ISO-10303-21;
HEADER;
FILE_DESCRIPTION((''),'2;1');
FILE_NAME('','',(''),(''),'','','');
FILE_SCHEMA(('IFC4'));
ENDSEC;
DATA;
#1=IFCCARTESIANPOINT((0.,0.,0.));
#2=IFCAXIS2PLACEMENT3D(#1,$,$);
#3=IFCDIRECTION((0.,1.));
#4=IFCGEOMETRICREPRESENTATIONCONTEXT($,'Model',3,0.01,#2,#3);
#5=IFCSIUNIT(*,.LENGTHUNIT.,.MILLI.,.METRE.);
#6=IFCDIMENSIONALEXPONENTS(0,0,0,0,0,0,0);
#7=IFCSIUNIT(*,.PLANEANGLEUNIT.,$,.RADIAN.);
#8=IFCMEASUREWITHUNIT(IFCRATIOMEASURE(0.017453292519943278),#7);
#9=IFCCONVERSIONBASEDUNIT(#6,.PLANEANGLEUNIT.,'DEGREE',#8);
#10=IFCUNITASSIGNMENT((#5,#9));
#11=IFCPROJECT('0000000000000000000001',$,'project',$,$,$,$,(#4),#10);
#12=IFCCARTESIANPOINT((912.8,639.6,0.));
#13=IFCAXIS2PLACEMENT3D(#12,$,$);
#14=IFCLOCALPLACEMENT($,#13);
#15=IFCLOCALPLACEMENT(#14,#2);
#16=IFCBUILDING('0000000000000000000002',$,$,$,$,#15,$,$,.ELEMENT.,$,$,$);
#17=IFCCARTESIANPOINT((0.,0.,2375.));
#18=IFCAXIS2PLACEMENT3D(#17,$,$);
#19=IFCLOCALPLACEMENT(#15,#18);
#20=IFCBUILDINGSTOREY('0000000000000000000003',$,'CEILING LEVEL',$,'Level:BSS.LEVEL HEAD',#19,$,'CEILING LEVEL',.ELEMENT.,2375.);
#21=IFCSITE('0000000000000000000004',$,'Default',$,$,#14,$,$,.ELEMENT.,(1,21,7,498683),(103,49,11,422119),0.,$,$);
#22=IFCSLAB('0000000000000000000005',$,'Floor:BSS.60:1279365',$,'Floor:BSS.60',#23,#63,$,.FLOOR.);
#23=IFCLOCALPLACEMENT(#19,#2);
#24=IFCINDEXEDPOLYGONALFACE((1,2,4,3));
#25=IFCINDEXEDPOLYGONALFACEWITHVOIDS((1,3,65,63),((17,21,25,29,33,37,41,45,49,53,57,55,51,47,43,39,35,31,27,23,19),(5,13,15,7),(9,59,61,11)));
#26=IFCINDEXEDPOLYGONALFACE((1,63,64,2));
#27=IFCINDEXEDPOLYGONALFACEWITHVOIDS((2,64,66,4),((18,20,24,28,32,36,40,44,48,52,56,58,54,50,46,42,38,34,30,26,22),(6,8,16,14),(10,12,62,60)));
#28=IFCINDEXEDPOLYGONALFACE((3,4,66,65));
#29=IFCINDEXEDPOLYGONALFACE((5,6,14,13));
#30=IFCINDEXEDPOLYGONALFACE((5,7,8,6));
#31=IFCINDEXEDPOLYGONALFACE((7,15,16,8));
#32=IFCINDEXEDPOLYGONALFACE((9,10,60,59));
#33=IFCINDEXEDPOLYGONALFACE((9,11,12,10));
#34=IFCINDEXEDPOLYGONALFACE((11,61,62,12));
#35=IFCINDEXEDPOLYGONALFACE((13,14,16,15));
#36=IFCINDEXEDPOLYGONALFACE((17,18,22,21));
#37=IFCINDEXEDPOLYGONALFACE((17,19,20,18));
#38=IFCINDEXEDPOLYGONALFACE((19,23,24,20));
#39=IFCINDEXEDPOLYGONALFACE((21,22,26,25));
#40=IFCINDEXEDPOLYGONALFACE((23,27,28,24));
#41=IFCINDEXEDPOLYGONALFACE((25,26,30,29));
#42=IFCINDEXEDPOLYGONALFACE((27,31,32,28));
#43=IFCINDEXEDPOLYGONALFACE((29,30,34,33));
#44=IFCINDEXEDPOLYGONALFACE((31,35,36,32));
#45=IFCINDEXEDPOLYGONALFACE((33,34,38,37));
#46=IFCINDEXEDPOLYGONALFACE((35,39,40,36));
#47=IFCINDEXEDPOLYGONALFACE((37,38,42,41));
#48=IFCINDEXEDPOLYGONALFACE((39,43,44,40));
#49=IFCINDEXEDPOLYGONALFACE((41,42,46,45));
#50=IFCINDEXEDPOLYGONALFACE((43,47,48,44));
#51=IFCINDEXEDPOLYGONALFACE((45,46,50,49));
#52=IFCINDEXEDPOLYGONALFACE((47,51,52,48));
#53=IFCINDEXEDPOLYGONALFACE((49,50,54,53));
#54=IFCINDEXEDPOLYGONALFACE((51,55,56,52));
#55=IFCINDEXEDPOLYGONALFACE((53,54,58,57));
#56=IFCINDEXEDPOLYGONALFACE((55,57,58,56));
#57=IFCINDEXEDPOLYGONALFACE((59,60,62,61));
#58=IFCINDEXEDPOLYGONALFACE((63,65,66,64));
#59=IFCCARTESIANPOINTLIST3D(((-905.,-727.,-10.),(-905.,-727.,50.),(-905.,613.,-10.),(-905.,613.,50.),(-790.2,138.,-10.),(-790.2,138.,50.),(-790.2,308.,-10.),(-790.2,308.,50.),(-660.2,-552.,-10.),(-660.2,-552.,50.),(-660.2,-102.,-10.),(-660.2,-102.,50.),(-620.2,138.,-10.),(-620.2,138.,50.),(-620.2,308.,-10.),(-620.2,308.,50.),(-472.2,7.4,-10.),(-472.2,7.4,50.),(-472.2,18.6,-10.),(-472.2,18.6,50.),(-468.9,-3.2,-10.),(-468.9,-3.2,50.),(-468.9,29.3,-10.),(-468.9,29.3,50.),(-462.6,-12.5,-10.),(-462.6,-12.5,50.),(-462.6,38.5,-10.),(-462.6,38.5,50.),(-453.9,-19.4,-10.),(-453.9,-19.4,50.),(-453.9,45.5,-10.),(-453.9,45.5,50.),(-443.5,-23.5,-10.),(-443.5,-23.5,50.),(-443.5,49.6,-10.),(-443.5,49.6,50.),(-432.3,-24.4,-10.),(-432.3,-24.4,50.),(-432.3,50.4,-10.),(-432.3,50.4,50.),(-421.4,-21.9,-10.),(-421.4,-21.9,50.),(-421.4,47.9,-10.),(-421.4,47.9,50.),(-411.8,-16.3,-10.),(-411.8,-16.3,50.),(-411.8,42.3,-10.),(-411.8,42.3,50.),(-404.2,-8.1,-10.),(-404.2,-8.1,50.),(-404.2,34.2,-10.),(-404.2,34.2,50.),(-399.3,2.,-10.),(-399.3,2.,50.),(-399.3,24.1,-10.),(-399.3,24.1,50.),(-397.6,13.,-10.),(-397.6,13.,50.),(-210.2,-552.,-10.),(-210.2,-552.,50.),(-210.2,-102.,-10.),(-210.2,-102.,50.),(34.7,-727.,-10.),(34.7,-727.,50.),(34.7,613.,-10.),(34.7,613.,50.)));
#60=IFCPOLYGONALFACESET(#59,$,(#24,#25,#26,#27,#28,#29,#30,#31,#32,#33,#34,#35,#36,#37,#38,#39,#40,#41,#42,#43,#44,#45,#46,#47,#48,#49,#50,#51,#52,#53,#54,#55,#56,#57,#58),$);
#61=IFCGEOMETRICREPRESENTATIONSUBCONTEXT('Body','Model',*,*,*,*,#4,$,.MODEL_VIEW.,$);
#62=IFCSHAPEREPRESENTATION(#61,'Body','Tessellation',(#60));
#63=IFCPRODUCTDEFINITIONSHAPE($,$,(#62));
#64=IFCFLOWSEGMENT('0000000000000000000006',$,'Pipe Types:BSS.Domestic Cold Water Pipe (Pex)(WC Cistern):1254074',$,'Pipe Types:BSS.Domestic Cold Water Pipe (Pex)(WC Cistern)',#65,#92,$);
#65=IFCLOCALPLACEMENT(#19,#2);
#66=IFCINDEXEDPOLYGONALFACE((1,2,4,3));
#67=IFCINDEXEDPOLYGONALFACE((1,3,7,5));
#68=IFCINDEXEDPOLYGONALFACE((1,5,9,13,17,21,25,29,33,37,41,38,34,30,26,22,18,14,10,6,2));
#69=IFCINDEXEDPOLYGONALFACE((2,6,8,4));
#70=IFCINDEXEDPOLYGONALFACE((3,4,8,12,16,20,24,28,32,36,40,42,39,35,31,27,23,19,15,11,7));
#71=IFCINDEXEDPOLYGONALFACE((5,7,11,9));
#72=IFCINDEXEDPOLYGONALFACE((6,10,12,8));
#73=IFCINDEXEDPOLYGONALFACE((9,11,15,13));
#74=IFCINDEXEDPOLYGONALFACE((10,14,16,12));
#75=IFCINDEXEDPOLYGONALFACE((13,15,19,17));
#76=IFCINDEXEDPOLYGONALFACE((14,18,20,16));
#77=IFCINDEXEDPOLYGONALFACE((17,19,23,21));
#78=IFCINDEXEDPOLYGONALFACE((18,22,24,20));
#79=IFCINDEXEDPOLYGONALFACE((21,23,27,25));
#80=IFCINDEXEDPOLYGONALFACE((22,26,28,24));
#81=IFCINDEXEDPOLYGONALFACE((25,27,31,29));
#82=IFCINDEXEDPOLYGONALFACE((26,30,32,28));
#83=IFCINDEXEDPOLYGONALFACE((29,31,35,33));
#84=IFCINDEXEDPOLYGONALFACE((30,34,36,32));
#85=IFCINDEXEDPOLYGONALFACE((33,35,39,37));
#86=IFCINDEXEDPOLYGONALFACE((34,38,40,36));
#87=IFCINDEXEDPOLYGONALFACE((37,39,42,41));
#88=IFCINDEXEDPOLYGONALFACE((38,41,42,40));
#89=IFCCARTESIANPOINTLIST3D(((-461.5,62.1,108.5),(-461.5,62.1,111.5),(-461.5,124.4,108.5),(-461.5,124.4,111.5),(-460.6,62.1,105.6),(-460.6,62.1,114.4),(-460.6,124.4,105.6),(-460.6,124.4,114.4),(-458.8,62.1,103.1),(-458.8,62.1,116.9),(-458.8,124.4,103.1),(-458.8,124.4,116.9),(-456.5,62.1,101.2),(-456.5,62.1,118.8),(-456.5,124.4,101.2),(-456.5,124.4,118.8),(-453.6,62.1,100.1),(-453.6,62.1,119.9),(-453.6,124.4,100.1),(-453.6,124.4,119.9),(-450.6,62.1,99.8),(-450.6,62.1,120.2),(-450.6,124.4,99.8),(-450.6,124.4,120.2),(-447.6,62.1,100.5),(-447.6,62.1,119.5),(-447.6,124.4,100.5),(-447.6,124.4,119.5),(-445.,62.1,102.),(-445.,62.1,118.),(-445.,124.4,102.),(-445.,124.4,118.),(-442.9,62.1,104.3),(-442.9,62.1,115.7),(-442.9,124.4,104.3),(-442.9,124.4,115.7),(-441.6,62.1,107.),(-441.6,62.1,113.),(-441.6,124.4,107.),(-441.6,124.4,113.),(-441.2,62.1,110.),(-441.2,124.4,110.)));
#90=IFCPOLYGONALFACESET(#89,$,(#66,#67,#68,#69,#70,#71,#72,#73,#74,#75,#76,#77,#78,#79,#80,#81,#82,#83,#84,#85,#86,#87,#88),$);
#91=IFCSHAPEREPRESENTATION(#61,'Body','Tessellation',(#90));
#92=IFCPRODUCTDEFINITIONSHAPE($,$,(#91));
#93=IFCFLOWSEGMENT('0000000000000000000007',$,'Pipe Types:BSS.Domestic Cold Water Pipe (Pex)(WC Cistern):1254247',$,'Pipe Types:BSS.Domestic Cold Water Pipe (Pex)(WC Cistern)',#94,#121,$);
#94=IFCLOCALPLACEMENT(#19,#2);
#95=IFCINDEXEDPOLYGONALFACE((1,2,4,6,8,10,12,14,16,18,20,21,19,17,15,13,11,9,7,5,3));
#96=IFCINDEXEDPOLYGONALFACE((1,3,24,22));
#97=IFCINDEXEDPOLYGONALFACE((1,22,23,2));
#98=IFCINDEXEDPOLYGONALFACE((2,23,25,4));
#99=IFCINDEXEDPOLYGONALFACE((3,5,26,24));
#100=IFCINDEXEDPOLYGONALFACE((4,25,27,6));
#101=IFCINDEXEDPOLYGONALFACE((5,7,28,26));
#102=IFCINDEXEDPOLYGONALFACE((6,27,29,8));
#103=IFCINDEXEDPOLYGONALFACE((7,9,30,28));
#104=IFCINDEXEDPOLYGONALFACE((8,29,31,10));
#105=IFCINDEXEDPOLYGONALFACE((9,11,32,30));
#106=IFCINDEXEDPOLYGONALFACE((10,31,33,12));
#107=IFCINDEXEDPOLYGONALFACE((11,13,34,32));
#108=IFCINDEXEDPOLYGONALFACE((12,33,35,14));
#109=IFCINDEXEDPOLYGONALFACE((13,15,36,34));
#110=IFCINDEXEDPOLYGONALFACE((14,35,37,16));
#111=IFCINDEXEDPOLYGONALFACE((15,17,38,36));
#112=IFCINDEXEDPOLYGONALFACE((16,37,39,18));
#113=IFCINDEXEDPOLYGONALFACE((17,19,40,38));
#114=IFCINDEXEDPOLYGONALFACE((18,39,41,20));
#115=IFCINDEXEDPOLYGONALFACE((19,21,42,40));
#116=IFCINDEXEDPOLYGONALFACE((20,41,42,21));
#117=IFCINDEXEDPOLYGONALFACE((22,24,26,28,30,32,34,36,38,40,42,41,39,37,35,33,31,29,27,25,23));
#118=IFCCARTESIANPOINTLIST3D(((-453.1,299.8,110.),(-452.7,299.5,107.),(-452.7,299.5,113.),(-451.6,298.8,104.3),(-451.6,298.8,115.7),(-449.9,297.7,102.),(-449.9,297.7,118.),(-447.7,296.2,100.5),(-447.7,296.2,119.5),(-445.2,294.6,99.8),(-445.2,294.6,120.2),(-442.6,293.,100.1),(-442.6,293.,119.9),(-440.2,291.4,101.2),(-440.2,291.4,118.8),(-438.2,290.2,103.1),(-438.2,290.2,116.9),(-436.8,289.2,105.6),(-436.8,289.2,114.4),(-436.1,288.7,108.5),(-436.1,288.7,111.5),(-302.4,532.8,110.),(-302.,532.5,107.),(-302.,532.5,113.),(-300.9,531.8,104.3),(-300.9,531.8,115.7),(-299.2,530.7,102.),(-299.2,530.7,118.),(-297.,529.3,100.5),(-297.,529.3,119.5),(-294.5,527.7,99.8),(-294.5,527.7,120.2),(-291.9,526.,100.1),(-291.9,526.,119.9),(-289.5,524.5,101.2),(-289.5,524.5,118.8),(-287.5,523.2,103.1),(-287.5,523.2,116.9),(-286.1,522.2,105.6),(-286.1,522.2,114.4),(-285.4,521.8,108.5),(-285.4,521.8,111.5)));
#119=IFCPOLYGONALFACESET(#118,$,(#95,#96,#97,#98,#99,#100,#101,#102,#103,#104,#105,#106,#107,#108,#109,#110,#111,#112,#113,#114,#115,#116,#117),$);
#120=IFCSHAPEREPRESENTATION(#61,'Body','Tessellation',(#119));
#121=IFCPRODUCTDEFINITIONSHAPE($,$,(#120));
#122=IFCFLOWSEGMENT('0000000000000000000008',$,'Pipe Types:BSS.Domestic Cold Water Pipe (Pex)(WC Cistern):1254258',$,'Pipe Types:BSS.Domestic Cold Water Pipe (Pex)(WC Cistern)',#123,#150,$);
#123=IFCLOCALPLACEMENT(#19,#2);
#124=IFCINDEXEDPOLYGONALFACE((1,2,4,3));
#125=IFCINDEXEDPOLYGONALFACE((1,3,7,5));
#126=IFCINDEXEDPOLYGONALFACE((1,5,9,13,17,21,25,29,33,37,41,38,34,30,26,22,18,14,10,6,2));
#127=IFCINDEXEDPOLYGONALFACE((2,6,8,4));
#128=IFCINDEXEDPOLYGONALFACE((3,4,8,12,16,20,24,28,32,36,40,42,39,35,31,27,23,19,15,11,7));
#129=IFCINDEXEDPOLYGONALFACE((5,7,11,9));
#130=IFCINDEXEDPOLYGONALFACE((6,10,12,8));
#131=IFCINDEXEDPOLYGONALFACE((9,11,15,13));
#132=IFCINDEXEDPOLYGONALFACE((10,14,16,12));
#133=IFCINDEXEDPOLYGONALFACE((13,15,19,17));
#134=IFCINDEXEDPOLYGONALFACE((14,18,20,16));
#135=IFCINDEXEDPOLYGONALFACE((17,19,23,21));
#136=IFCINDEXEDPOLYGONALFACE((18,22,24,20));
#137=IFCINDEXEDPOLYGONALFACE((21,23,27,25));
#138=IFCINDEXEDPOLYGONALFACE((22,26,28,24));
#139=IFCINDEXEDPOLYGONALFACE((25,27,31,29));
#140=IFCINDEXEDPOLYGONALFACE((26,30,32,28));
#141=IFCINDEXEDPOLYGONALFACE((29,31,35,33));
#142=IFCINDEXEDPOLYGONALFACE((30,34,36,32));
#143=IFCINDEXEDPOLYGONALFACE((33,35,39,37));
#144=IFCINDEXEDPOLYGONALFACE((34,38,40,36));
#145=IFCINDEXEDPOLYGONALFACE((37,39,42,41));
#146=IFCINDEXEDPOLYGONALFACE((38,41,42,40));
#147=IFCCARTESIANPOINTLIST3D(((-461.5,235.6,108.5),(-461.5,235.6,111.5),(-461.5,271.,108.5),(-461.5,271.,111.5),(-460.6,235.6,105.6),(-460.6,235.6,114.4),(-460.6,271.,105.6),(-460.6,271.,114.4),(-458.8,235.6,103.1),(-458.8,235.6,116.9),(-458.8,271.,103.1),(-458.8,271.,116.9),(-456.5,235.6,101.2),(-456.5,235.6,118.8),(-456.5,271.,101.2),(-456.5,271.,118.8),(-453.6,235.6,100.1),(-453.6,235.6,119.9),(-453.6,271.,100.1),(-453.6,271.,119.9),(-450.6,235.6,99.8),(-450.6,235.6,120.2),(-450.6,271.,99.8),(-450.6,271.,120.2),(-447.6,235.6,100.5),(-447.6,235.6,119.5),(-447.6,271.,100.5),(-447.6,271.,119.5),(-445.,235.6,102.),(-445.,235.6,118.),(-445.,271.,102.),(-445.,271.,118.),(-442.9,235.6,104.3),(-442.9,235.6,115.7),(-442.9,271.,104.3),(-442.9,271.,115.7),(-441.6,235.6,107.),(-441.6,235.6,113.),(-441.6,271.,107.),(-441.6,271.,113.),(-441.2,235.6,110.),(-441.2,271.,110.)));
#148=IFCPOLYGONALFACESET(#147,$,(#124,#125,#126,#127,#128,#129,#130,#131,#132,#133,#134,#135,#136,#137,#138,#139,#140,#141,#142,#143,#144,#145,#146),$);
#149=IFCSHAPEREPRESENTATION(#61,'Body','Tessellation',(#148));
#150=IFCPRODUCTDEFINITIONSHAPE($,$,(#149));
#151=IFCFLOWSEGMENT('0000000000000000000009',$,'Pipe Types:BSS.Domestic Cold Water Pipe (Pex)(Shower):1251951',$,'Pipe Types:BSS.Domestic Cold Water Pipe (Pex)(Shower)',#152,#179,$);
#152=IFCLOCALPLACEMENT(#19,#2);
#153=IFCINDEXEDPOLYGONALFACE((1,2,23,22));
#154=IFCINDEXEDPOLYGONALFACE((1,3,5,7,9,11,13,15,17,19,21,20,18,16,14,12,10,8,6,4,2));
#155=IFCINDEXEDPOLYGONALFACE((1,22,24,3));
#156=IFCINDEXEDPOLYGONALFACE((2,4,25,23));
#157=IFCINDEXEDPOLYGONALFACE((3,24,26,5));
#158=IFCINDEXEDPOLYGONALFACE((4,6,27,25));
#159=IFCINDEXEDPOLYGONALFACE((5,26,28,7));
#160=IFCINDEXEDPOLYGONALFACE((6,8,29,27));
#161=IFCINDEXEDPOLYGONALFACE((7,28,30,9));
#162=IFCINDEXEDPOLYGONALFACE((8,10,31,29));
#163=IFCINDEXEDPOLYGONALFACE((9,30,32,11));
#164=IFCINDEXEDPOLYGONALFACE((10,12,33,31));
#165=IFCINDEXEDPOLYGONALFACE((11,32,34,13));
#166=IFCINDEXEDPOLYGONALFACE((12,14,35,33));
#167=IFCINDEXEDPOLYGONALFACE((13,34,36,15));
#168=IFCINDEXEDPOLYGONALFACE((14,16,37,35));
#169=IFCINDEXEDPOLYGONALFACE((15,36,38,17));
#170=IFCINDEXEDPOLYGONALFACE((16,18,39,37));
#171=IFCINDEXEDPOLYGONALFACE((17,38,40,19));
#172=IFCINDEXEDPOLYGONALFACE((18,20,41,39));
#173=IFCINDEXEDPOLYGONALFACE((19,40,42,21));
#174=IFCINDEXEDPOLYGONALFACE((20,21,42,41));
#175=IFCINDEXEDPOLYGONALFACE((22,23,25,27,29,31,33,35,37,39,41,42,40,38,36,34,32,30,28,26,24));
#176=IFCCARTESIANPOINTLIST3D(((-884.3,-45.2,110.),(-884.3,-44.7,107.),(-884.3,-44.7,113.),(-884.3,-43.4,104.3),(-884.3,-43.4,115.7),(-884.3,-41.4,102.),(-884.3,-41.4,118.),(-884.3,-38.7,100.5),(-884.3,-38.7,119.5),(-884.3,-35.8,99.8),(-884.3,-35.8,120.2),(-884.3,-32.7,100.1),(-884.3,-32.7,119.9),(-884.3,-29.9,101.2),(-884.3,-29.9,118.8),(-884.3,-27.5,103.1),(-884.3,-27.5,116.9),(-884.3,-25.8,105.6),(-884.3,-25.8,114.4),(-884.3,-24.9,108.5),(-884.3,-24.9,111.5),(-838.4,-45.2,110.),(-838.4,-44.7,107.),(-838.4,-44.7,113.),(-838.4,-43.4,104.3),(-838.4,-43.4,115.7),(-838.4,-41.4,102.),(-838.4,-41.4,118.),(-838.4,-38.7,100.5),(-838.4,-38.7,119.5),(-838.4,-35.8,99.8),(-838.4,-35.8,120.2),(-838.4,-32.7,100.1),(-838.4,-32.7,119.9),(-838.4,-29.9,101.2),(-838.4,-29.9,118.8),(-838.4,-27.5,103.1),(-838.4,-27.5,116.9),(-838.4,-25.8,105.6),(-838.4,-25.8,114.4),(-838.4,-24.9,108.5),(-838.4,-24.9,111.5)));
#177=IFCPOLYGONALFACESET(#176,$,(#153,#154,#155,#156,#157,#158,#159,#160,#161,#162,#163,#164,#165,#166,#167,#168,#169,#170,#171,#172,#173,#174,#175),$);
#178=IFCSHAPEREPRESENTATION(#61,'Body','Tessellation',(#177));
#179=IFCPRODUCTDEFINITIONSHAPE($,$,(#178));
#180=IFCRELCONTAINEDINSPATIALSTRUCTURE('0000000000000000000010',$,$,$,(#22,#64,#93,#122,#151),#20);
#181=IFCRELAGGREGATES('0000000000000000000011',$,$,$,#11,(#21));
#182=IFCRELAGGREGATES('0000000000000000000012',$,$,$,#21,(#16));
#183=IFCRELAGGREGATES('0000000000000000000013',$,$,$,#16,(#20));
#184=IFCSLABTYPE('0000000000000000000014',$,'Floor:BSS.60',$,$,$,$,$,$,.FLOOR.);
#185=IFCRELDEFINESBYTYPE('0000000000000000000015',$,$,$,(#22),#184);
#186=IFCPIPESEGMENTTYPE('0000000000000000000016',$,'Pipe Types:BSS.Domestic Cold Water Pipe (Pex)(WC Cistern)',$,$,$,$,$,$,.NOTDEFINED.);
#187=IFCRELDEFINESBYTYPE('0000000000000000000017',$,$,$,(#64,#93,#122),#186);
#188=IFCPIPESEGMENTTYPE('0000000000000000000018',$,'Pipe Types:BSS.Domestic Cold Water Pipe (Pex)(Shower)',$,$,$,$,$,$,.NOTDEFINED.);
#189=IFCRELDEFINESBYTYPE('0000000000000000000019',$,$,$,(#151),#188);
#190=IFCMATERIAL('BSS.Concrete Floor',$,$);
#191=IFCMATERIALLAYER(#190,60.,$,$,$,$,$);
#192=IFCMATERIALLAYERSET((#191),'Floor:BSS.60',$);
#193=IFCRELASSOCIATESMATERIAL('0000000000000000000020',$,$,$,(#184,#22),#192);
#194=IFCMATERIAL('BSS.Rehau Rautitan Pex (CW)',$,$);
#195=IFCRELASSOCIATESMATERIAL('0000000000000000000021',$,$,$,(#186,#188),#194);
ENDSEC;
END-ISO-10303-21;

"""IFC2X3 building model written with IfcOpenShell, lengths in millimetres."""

from ifc_helpers import new_model, entity, si_unit, converted_unit, direction, frame, frame_2d, origin, origin_2d_with_axis, place, context, subcontext, project, spatial, rectangle, circle, extrude, material, layer, layer_set, layer_usage, type_object, element, save


model = new_model("IFC2X3")

# Units and contexts
model_context = context("Model", 3, precision=0.01, world=origin(), true_north=direction((0.0, 1.0)))
body_context = subcontext(model_context, "Body", "Model", "MODEL_VIEW")
ifc_project = project(units=[si_unit("LENGTHUNIT", "METRE", prefix="MILLI"), converted_unit("PLANEANGLEUNIT", "DEGREE", entity("IfcRatioMeasure", 0.017453292519943278), si_unit("PLANEANGLEUNIT", "RADIAN"), dimensions=[0, 0, 0, 0, 0, 0, 0])], contexts=[model_context])

# Site, building, storey
site_placement = place(None, frame((912.8, 639.6, 0.0)))
site = spatial("IfcSite", under=ifc_project, at=site_placement, Name="Default", CompositionType="ELEMENT", RefLatitude=(1, 21, 7, 498683), RefLongitude=(103, 49, 11, 422119), RefElevation=0.0)
building_placement = place(site_placement, origin())
building = spatial("IfcBuilding", under=site, at=building_placement, CompositionType="ELEMENT")
storey_placement = place(building_placement, frame((0.0, 0.0, 2375.0)))
storey = spatial("IfcBuildingStorey", under=building, at=storey_placement, Name="CEILING LEVEL", ObjectType="Level:BSS.LEVEL HEAD", LongName="CEILING LEVEL", CompositionType="ELEMENT", Elevation=2375.0)

# Slab, openings
ifc_material_1 = material(Name="BSS.Concrete Floor")
ifc_layer = layer(ifc_material_1, 60.0)
ifc_layer_set = layer_set([ifc_layer], Name="Floor:BSS.60")
ifc_layer_usage = layer_usage(ifc_layer_set, "AXIS3", "POSITIVE", 0.0)
slab_type = type_object("IfcSlabType", Name="Floor:BSS.60", PredefinedType="FLOOR", material=ifc_layer_set)
slab_placement = place(storey_placement, frame((-905.0, -727.0, -10.0)))
slab = element("IfcSlab", 1, at=slab_placement, inside=storey, type_object=slab_type, material=ifc_layer_usage, Name="Floor:BSS.60:1279365", ObjectType="Floor:BSS.60", PredefinedType="FLOOR", context=body_context, shape_type="SweptSolid", body=[
    extrude(rectangle(XDim=1340.0, YDim=939.7, at=frame_2d((0.0, 0.0), x_axis=(0.0, -1.0))), frame((469.9, 670.0, 60.0), z_axis=(0.0, 0.0, -1.0), x_axis=(-1.0, 0.0, 0.0)), (0.0, 0.0, 1.0), 60.0),
])
opening_1_placement = place(slab_placement, frame((469.9, 740.0, 60.0)))
element("IfcOpeningElement", 2, at=opening_1_placement, cuts=slab, ObjectType="Opening", context=body_context, shape_type="SweptSolid", body=[
    extrude(circle(Radius=37.5, at=origin_2d_with_axis()), frame((0.0, 0.0, 0.0), z_axis=(0.0, 0.0, -1.0), x_axis=(1.0, 0.0, 0.0)), (0.0, 0.0, 1.0), 60.0),
])
opening_2_placement = place(slab_placement, frame((199.8, 950.0, 60.0)))
element("IfcOpeningElement", 3, at=opening_2_placement, cuts=slab, ObjectType="Opening", context=body_context, shape_type="SweptSolid", body=[
    extrude(rectangle(XDim=170.0, YDim=170.0, at=origin_2d_with_axis()), frame((0.0, 0.0, 0.0), z_axis=(0.0, 0.0, -1.0), x_axis=(0.0, -1.0, 0.0)), (0.0, 0.0, 1.0), 60.0),
])
opening_3_placement = place(slab_placement, frame((469.8, 400.0, 60.0)))
element("IfcOpeningElement", 4, at=opening_3_placement, cuts=slab, ObjectType="Opening", context=body_context, shape_type="SweptSolid", body=[
    extrude(rectangle(XDim=450.0, YDim=450.0, at=origin_2d_with_axis()), frame((0.0, 0.0, 0.0), z_axis=(0.0, 0.0, -1.0), x_axis=(0.0, -1.0, 0.0)), (0.0, 0.0, 1.0), 60.0),
])

# Flow segments
ifc_material_2 = material(Name="BSS.Rehau Rautitan Pex (CW)")
pipe_segment_type_1 = type_object("IfcPipeSegmentType", Name="Pipe Types:BSS.Domestic Cold Water Pipe (Pex)(WC Cistern)", PredefinedType="NOTDEFINED", material=ifc_material_2)
flow_segment_1_placement = place(storey_placement, origin())
element("IfcFlowSegment", 5, at=flow_segment_1_placement, inside=storey, type_object=pipe_segment_type_1, Name="Pipe Types:BSS.Domestic Cold Water Pipe (Pex)(WC Cistern):1254074", ObjectType="Pipe Types:BSS.Domestic Cold Water Pipe (Pex)(WC Cistern)", context=body_context, shape_type="SweptSolid", body=[
    extrude(circle(Radius=10.2, at=frame_2d((0.0, 0.0), x_axis=(1.0, 0.0))), frame((-451.4, 62.1, 110.0), z_axis=(0.0, 1.0, 0.0), x_axis=(1.0, 0.0, 0.0)), (0.0, 0.0, 1.0), 62.3),
])
flow_segment_2_placement = place(storey_placement, origin())
element("IfcFlowSegment", 6, at=flow_segment_2_placement, inside=storey, type_object=pipe_segment_type_1, Name="Pipe Types:BSS.Domestic Cold Water Pipe (Pex)(WC Cistern):1254247", ObjectType="Pipe Types:BSS.Domestic Cold Water Pipe (Pex)(WC Cistern)", context=body_context, shape_type="SweptSolid", body=[
    extrude(circle(Radius=10.2, at=origin_2d_with_axis()), frame((-444.5, 294.2, 110.0), z_axis=(0.543056, 0.839696, 0.0), x_axis=(-0.839696, 0.543056, 0.0)), (0.0, 0.0, 1.0), 277.5),
])
flow_segment_3_placement = place(storey_placement, origin())
element("IfcFlowSegment", 7, at=flow_segment_3_placement, inside=storey, type_object=pipe_segment_type_1, Name="Pipe Types:BSS.Domestic Cold Water Pipe (Pex)(WC Cistern):1254258", ObjectType="Pipe Types:BSS.Domestic Cold Water Pipe (Pex)(WC Cistern)", context=body_context, shape_type="SweptSolid", body=[
    extrude(circle(Radius=10.2, at=frame_2d((0.0, 0.0), x_axis=(1.0, 0.0))), frame((-451.4, 235.6, 110.0), z_axis=(0.0, 1.0, 0.0), x_axis=(1.0, 0.0, 0.0)), (0.0, 0.0, 1.0), 35.5),
])
pipe_segment_type_2 = type_object("IfcPipeSegmentType", Name="Pipe Types:BSS.Domestic Cold Water Pipe (Pex)(Shower)", PredefinedType="NOTDEFINED", material=ifc_material_2)
flow_segment_4_placement = place(storey_placement, origin())
element("IfcFlowSegment", 8, at=flow_segment_4_placement, inside=storey, type_object=pipe_segment_type_2, Name="Pipe Types:BSS.Domestic Cold Water Pipe (Pex)(Shower):1251951", ObjectType="Pipe Types:BSS.Domestic Cold Water Pipe (Pex)(Shower)", context=body_context, shape_type="SweptSolid", body=[
    extrude(circle(Radius=10.2, at=frame_2d((0.0, 0.0), x_axis=(1.0, 0.0))), frame((-884.3, -35.0, 110.0), z_axis=(1.0, 0.0, 0.0), x_axis=(0.0, -1.0, 0.0)), (0.0, 0.0, 1.0), 45.9),
])

save(model, "model.ifc")
